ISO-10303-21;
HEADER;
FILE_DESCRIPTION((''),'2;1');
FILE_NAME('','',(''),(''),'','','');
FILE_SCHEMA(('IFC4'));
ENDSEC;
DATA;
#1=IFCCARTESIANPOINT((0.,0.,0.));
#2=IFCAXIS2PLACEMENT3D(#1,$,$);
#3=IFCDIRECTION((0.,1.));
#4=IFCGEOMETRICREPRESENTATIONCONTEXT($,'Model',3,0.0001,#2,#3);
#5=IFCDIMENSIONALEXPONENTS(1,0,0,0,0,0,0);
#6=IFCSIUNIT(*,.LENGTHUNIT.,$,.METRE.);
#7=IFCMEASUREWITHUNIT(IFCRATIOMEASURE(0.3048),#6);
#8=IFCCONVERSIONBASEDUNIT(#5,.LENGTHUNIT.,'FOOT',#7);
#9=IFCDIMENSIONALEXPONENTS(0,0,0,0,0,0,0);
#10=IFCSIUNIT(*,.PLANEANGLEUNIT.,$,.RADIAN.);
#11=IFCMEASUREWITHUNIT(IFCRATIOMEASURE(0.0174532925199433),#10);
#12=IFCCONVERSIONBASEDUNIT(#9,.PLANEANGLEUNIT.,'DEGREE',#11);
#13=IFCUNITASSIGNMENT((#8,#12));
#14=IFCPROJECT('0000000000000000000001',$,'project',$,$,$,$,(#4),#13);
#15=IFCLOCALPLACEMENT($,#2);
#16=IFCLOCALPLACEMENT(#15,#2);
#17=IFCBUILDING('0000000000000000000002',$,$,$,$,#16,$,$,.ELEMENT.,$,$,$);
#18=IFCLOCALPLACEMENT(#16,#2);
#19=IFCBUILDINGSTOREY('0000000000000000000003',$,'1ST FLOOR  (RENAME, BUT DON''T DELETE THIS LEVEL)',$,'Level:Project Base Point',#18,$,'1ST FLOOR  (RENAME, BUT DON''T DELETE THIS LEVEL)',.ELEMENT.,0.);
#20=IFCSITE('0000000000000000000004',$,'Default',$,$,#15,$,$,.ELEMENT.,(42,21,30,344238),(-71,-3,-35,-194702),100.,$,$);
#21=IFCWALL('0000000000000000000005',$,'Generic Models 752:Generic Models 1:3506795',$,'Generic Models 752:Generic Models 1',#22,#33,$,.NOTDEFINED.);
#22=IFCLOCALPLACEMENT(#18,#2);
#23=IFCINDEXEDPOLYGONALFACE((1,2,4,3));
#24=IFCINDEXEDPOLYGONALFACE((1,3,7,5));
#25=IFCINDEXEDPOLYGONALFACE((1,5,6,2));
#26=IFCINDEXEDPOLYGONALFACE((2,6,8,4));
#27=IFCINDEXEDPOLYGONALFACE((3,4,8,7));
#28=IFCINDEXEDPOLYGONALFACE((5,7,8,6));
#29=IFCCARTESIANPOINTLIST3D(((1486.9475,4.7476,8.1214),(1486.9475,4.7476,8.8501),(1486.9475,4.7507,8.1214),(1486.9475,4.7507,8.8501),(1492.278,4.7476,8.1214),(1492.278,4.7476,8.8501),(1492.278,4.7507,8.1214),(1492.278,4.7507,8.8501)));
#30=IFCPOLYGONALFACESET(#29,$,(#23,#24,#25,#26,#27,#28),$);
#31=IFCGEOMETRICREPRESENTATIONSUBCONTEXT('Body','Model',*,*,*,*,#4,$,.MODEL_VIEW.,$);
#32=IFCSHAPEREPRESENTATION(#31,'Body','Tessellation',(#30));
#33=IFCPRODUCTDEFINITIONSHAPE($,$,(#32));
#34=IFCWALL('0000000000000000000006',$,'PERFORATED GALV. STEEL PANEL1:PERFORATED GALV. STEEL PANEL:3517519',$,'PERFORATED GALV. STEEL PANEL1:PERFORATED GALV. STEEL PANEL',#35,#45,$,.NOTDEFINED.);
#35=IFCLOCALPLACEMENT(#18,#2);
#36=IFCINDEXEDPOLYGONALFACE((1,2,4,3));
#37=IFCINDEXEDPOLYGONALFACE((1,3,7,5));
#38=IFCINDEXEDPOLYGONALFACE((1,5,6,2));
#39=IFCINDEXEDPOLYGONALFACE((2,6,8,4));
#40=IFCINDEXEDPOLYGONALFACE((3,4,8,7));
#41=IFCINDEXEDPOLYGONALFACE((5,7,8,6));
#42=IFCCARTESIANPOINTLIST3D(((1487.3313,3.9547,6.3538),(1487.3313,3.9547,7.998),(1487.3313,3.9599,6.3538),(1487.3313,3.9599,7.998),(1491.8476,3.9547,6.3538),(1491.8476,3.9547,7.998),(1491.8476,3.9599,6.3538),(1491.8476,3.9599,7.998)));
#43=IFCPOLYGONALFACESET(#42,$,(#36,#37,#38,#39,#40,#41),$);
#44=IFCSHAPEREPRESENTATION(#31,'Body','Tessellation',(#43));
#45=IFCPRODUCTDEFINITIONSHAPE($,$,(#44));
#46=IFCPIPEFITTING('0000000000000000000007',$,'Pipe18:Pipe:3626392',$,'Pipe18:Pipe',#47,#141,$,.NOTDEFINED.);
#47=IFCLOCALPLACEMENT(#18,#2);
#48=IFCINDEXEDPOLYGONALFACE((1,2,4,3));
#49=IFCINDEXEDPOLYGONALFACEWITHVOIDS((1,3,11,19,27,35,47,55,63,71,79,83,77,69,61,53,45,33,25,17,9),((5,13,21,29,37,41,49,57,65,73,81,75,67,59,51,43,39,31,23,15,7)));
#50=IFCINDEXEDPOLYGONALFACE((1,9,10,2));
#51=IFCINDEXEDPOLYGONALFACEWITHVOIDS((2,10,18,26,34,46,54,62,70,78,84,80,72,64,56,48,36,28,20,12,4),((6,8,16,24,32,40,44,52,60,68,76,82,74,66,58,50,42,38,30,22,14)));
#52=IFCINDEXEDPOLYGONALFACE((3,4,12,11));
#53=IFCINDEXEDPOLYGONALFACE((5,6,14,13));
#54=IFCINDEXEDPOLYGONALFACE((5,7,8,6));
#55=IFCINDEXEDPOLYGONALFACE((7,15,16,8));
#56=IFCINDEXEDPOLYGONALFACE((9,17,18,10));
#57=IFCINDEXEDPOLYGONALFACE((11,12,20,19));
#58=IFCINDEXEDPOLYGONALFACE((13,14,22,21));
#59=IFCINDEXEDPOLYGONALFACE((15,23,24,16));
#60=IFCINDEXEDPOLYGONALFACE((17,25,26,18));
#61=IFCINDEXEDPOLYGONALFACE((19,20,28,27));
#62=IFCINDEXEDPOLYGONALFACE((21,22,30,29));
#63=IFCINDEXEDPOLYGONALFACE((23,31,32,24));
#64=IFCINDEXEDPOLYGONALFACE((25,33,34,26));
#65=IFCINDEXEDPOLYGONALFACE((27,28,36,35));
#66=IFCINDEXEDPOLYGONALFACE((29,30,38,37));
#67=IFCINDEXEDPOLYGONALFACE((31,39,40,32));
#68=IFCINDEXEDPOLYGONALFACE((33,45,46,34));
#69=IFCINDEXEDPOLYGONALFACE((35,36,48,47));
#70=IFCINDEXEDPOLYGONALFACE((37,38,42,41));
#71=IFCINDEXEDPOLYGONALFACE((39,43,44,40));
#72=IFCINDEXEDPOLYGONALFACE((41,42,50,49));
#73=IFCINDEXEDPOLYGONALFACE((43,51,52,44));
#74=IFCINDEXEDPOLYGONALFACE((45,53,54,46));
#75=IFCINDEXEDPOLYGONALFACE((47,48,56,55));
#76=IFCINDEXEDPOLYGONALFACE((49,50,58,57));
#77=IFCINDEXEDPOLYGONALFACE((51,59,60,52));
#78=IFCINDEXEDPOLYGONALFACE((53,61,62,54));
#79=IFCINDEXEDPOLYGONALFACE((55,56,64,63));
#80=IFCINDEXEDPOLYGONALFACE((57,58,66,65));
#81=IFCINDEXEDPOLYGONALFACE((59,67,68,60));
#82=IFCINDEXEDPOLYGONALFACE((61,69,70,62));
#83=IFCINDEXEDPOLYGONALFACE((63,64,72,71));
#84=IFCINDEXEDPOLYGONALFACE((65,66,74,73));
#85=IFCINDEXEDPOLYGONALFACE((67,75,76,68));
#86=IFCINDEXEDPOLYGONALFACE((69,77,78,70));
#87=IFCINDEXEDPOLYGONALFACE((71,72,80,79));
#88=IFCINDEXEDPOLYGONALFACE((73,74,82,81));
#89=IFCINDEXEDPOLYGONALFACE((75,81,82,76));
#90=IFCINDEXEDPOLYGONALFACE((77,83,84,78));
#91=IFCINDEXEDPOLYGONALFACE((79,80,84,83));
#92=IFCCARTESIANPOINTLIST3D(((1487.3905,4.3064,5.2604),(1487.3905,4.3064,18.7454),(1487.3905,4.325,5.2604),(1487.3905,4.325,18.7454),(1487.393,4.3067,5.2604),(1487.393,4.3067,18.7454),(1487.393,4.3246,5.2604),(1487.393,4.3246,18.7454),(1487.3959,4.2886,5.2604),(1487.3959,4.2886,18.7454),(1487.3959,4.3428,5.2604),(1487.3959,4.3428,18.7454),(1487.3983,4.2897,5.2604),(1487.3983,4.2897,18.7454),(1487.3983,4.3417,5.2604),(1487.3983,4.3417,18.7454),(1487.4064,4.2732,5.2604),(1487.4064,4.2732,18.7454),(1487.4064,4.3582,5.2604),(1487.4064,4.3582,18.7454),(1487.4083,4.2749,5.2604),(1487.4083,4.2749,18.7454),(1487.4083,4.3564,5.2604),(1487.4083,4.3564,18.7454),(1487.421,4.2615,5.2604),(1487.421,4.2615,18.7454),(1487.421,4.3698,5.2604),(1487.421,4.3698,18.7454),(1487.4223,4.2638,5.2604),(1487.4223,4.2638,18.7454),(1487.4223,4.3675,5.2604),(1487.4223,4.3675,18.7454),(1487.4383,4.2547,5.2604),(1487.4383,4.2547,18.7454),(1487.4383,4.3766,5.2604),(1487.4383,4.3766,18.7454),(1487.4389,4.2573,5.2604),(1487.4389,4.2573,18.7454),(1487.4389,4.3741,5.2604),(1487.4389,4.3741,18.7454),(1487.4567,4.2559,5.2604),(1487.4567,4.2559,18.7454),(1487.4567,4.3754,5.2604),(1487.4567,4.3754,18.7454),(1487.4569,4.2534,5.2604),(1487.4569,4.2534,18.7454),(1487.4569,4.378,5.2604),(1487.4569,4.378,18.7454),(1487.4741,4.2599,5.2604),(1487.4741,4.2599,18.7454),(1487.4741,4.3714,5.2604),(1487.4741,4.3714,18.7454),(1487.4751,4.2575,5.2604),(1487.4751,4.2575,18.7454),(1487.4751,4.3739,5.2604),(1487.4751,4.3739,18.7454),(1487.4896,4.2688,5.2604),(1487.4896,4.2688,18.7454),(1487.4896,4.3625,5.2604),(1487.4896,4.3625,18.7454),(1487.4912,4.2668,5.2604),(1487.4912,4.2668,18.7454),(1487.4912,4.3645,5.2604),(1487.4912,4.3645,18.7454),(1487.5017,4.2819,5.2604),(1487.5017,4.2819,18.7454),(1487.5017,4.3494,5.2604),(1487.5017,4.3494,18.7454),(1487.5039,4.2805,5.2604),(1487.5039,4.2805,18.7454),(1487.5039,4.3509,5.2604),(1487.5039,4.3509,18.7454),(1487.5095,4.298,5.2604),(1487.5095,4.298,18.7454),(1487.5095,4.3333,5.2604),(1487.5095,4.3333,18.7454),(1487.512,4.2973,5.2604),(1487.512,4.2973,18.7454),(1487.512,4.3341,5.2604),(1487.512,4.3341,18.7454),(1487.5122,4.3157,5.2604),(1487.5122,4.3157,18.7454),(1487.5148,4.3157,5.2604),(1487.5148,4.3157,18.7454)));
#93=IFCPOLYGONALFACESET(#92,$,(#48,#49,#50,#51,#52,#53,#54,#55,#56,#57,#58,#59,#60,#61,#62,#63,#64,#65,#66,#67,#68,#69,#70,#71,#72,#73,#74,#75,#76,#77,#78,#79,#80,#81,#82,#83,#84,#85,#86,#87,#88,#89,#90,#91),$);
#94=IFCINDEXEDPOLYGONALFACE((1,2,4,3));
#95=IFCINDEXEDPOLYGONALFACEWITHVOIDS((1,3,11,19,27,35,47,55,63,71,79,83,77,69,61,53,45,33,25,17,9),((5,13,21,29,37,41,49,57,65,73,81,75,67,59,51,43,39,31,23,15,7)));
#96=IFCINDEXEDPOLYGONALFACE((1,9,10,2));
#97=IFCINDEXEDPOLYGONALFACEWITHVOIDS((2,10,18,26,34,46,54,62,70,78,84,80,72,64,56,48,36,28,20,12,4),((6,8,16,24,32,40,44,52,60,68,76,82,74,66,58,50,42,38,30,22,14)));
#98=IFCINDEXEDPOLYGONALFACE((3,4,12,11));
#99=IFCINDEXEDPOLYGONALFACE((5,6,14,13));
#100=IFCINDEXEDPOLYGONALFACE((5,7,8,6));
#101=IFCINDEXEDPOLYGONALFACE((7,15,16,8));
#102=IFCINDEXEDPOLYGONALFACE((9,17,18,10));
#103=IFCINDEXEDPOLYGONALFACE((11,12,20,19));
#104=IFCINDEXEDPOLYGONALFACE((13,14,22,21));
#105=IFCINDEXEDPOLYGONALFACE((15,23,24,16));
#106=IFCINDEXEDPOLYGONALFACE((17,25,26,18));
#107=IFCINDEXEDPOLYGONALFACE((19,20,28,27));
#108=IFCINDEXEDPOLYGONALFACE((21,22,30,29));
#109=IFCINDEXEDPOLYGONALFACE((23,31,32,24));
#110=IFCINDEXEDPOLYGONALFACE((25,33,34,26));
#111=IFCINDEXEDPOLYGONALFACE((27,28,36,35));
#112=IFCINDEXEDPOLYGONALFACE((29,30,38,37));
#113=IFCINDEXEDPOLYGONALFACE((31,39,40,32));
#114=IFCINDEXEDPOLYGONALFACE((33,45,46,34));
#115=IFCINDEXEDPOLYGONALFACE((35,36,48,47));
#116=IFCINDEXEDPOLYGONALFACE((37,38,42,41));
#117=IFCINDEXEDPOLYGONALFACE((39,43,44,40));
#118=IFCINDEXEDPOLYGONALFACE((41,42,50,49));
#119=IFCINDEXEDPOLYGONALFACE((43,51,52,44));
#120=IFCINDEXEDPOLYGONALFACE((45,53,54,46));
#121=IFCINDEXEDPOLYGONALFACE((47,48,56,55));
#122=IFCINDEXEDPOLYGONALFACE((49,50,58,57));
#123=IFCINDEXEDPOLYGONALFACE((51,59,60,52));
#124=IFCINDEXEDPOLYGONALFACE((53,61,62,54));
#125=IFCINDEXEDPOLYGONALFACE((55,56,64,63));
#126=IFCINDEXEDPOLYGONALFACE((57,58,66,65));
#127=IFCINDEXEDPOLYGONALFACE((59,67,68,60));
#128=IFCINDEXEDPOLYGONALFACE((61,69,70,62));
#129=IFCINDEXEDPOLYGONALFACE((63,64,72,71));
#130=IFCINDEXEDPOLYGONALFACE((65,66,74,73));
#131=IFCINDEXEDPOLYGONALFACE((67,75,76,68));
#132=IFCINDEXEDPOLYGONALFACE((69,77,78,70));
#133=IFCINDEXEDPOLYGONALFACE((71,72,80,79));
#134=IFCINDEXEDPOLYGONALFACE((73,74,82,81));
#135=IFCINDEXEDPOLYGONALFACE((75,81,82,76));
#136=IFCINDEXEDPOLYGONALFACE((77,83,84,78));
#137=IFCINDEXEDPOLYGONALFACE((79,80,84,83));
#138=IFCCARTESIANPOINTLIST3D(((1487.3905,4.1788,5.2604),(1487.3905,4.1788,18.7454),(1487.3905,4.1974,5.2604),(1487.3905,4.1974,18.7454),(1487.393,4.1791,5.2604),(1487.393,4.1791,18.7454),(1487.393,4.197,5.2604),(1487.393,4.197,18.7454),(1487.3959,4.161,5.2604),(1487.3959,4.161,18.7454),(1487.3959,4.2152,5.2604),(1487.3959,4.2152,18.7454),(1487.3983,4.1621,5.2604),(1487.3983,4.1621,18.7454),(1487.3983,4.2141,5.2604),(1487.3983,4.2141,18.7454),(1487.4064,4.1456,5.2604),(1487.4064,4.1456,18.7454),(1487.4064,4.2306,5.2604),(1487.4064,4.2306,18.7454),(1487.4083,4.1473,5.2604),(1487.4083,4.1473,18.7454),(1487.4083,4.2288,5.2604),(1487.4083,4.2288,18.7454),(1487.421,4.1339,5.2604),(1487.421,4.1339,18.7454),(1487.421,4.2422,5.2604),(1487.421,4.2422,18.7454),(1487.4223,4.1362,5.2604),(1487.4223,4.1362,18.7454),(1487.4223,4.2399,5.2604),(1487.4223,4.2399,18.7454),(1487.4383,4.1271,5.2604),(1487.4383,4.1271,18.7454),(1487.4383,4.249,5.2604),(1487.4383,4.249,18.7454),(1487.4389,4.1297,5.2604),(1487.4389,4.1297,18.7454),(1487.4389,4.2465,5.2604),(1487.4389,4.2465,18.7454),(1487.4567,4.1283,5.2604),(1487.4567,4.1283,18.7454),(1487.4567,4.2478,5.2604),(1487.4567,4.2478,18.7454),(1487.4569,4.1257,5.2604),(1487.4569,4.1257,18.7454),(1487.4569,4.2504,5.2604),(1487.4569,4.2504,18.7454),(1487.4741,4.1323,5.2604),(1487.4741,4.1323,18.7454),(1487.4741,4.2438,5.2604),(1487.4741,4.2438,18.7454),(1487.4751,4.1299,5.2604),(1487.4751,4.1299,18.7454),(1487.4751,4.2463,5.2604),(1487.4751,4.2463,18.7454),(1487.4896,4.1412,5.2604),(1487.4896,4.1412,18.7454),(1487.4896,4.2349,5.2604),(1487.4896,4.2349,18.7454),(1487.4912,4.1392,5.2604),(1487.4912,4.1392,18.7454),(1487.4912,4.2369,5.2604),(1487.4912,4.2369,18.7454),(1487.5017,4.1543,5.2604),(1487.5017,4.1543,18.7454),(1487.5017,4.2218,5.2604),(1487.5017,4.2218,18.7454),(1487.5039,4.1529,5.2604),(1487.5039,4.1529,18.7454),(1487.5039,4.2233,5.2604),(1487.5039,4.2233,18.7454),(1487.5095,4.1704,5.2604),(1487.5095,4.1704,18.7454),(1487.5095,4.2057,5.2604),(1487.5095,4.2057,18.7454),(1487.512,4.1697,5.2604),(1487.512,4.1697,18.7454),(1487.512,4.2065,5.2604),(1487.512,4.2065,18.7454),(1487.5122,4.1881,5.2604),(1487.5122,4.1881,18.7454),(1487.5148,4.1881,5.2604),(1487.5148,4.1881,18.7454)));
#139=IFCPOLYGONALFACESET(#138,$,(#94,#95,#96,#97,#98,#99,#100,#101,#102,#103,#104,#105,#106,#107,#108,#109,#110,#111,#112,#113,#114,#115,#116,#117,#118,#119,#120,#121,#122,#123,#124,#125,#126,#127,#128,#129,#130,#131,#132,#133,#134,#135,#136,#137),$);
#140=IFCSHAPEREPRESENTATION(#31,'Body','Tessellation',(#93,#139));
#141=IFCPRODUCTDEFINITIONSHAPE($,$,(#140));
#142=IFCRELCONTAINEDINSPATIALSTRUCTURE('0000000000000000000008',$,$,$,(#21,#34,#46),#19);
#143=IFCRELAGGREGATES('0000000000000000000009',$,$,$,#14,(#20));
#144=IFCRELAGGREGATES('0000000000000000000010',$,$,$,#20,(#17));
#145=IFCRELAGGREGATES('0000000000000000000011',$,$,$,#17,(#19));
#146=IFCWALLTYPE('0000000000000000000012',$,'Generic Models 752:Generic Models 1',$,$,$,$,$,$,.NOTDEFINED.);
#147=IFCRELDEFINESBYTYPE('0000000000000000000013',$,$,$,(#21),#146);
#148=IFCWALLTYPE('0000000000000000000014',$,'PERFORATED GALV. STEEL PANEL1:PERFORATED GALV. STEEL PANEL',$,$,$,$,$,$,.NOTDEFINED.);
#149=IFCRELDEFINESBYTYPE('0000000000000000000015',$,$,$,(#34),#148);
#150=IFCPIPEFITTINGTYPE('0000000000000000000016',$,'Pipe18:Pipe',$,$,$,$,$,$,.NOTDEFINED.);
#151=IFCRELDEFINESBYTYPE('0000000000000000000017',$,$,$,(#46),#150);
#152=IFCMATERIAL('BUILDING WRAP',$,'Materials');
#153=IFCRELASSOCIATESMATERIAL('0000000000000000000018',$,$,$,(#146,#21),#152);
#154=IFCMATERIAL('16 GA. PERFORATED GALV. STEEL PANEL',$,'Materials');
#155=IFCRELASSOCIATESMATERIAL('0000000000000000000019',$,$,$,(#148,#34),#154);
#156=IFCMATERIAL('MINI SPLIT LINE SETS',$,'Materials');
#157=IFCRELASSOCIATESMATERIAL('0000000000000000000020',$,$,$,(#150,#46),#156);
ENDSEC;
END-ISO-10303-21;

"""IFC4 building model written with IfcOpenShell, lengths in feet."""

from ifc_helpers import new_model, entity, si_unit, converted_unit, direction, frame, frame_2d, origin, origin_2d_with_axis, place, context, subcontext, project, spatial, rectangle, hollow_circle, extrude, source, transform, mapped, material, type_object, type_shapes, element, save


model = new_model("IFC4")

# Units and contexts
model_context = context("Model", 3, precision=0.0001, world=origin(), true_north=direction((0.0, 1.0)))
body_context = subcontext(model_context, "Body", "Model", "MODEL_VIEW")
ifc_project = project(units=[converted_unit("LENGTHUNIT", "FOOT", entity("IfcRatioMeasure", 0.3048), si_unit("LENGTHUNIT", "METRE"), dimensions=[1, 0, 0, 0, 0, 0, 0]), converted_unit("PLANEANGLEUNIT", "DEGREE", entity("IfcRatioMeasure", 0.0174532925199433), si_unit("PLANEANGLEUNIT", "RADIAN"), dimensions=[0, 0, 0, 0, 0, 0, 0])], contexts=[model_context])

# Site, building, storey
site_placement = place(None, origin())
site = spatial("IfcSite", under=ifc_project, at=site_placement, Name="Default", CompositionType="ELEMENT", RefLatitude=(42, 21, 30, 344238), RefLongitude=(-71, -3, -35, -194702), RefElevation=100.0)
building_placement = place(site_placement, origin())
building = spatial("IfcBuilding", under=site, at=building_placement, CompositionType="ELEMENT")
storey_placement = place(building_placement, origin())
storey = spatial("IfcBuildingStorey", under=building, at=storey_placement, Name="1ST FLOOR  (RENAME, BUT DON'T DELETE THIS LEVEL)", ObjectType="Level:Project Base Point", LongName="1ST FLOOR  (RENAME, BUT DON'T DELETE THIS LEVEL)", CompositionType="ELEMENT", Elevation=0.0)

# Walls
ifc_material_1 = material(Name="BUILDING WRAP", Category="Materials")
wall_type_1 = type_object("IfcWallType", Name="Generic Models 752:Generic Models 1", PredefinedType="NOTDEFINED", material=ifc_material_1)
wall_1_placement = place(storey_placement, frame((1486.9475, 4.7476, 8.1214)))
element("IfcWall", 1, at=wall_1_placement, inside=storey, type_object=wall_type_1, material=ifc_material_1, Name="Generic Models 752:Generic Models 1:3506795", ObjectType="Generic Models 752:Generic Models 1", PredefinedType="NOTDEFINED", context=body_context, shape_type="SweptSolid", body=[
    extrude(rectangle(XDim=5.3305, YDim=0.0031, at=frame_2d((0.0, 0.0), x_axis=(1.0, 0.0))), frame((2.6653, 0.0016, 0.0)), (0.0, 0.0, 1.0), 0.7287),
])
ifc_material_2 = material(Name="16 GA. PERFORATED GALV. STEEL PANEL", Category="Materials")
wall_type_2 = type_object("IfcWallType", Name="PERFORATED GALV. STEEL PANEL1:PERFORATED GALV. STEEL PANEL", PredefinedType="NOTDEFINED", material=ifc_material_2)
wall_2_placement = place(storey_placement, frame((1487.3313, 3.9547, 6.3538)))
element("IfcWall", 2, at=wall_2_placement, inside=storey, type_object=wall_type_2, material=ifc_material_2, Name="PERFORATED GALV. STEEL PANEL1:PERFORATED GALV. STEEL PANEL:3517519", ObjectType="PERFORATED GALV. STEEL PANEL1:PERFORATED GALV. STEEL PANEL", PredefinedType="NOTDEFINED", context=body_context, shape_type="SweptSolid", body=[
    extrude(rectangle(XDim=4.5163, YDim=0.0053, at=frame_2d((0.0, 0.0), x_axis=(1.0, 0.0))), frame((2.2581, 0.0026, 0.0), z_axis=(0.0, 0.0, 1.0), x_axis=(-1.0, 0.0, 0.0)), (0.0, 0.0, 1.0), 1.6442),
])

# Pipe fitting
ifc_material_3 = material(Name="MINI SPLIT LINE SETS", Category="Materials")
pipe_fitting_type_1 = type_object("IfcPipeFittingType", Name="Pipe18:Pipe", PredefinedType="NOTDEFINED", material=ifc_material_3)
shared_shape_1 = source(origin(), body_context, "Body", "SweptSolid", [
    extrude(hollow_circle(Radius=0.0625, WallThickness=0.0026, at=origin_2d_with_axis()), frame((0.0677, 0.1953, 0.0)), (0.0, 0.0, 1.0), 13.485),
    extrude(hollow_circle(Radius=0.0625, WallThickness=0.0026, at=origin_2d_with_axis()), frame((0.0677, 0.0677, 0.0)), (0.0, 0.0, 1.0), 13.485),
])
type_shapes(pipe_fitting_type_1, [shared_shape_1])
pipe_fitting_1_placement = place(storey_placement, frame((1487.3845, 4.1203, 5.2604)))
element("IfcPipeFitting", 3, at=pipe_fitting_1_placement, inside=storey, type_object=pipe_fitting_type_1, material=ifc_material_3, Name="Pipe18:Pipe:3626392", ObjectType="Pipe18:Pipe", PredefinedType="NOTDEFINED", context=body_context, shape_type="MappedRepresentation", body=[
    mapped(shared_shape_1, transform((0.0, 0.0, 0.0), scale=1.0)),
])

save(model, "model.ifc")
